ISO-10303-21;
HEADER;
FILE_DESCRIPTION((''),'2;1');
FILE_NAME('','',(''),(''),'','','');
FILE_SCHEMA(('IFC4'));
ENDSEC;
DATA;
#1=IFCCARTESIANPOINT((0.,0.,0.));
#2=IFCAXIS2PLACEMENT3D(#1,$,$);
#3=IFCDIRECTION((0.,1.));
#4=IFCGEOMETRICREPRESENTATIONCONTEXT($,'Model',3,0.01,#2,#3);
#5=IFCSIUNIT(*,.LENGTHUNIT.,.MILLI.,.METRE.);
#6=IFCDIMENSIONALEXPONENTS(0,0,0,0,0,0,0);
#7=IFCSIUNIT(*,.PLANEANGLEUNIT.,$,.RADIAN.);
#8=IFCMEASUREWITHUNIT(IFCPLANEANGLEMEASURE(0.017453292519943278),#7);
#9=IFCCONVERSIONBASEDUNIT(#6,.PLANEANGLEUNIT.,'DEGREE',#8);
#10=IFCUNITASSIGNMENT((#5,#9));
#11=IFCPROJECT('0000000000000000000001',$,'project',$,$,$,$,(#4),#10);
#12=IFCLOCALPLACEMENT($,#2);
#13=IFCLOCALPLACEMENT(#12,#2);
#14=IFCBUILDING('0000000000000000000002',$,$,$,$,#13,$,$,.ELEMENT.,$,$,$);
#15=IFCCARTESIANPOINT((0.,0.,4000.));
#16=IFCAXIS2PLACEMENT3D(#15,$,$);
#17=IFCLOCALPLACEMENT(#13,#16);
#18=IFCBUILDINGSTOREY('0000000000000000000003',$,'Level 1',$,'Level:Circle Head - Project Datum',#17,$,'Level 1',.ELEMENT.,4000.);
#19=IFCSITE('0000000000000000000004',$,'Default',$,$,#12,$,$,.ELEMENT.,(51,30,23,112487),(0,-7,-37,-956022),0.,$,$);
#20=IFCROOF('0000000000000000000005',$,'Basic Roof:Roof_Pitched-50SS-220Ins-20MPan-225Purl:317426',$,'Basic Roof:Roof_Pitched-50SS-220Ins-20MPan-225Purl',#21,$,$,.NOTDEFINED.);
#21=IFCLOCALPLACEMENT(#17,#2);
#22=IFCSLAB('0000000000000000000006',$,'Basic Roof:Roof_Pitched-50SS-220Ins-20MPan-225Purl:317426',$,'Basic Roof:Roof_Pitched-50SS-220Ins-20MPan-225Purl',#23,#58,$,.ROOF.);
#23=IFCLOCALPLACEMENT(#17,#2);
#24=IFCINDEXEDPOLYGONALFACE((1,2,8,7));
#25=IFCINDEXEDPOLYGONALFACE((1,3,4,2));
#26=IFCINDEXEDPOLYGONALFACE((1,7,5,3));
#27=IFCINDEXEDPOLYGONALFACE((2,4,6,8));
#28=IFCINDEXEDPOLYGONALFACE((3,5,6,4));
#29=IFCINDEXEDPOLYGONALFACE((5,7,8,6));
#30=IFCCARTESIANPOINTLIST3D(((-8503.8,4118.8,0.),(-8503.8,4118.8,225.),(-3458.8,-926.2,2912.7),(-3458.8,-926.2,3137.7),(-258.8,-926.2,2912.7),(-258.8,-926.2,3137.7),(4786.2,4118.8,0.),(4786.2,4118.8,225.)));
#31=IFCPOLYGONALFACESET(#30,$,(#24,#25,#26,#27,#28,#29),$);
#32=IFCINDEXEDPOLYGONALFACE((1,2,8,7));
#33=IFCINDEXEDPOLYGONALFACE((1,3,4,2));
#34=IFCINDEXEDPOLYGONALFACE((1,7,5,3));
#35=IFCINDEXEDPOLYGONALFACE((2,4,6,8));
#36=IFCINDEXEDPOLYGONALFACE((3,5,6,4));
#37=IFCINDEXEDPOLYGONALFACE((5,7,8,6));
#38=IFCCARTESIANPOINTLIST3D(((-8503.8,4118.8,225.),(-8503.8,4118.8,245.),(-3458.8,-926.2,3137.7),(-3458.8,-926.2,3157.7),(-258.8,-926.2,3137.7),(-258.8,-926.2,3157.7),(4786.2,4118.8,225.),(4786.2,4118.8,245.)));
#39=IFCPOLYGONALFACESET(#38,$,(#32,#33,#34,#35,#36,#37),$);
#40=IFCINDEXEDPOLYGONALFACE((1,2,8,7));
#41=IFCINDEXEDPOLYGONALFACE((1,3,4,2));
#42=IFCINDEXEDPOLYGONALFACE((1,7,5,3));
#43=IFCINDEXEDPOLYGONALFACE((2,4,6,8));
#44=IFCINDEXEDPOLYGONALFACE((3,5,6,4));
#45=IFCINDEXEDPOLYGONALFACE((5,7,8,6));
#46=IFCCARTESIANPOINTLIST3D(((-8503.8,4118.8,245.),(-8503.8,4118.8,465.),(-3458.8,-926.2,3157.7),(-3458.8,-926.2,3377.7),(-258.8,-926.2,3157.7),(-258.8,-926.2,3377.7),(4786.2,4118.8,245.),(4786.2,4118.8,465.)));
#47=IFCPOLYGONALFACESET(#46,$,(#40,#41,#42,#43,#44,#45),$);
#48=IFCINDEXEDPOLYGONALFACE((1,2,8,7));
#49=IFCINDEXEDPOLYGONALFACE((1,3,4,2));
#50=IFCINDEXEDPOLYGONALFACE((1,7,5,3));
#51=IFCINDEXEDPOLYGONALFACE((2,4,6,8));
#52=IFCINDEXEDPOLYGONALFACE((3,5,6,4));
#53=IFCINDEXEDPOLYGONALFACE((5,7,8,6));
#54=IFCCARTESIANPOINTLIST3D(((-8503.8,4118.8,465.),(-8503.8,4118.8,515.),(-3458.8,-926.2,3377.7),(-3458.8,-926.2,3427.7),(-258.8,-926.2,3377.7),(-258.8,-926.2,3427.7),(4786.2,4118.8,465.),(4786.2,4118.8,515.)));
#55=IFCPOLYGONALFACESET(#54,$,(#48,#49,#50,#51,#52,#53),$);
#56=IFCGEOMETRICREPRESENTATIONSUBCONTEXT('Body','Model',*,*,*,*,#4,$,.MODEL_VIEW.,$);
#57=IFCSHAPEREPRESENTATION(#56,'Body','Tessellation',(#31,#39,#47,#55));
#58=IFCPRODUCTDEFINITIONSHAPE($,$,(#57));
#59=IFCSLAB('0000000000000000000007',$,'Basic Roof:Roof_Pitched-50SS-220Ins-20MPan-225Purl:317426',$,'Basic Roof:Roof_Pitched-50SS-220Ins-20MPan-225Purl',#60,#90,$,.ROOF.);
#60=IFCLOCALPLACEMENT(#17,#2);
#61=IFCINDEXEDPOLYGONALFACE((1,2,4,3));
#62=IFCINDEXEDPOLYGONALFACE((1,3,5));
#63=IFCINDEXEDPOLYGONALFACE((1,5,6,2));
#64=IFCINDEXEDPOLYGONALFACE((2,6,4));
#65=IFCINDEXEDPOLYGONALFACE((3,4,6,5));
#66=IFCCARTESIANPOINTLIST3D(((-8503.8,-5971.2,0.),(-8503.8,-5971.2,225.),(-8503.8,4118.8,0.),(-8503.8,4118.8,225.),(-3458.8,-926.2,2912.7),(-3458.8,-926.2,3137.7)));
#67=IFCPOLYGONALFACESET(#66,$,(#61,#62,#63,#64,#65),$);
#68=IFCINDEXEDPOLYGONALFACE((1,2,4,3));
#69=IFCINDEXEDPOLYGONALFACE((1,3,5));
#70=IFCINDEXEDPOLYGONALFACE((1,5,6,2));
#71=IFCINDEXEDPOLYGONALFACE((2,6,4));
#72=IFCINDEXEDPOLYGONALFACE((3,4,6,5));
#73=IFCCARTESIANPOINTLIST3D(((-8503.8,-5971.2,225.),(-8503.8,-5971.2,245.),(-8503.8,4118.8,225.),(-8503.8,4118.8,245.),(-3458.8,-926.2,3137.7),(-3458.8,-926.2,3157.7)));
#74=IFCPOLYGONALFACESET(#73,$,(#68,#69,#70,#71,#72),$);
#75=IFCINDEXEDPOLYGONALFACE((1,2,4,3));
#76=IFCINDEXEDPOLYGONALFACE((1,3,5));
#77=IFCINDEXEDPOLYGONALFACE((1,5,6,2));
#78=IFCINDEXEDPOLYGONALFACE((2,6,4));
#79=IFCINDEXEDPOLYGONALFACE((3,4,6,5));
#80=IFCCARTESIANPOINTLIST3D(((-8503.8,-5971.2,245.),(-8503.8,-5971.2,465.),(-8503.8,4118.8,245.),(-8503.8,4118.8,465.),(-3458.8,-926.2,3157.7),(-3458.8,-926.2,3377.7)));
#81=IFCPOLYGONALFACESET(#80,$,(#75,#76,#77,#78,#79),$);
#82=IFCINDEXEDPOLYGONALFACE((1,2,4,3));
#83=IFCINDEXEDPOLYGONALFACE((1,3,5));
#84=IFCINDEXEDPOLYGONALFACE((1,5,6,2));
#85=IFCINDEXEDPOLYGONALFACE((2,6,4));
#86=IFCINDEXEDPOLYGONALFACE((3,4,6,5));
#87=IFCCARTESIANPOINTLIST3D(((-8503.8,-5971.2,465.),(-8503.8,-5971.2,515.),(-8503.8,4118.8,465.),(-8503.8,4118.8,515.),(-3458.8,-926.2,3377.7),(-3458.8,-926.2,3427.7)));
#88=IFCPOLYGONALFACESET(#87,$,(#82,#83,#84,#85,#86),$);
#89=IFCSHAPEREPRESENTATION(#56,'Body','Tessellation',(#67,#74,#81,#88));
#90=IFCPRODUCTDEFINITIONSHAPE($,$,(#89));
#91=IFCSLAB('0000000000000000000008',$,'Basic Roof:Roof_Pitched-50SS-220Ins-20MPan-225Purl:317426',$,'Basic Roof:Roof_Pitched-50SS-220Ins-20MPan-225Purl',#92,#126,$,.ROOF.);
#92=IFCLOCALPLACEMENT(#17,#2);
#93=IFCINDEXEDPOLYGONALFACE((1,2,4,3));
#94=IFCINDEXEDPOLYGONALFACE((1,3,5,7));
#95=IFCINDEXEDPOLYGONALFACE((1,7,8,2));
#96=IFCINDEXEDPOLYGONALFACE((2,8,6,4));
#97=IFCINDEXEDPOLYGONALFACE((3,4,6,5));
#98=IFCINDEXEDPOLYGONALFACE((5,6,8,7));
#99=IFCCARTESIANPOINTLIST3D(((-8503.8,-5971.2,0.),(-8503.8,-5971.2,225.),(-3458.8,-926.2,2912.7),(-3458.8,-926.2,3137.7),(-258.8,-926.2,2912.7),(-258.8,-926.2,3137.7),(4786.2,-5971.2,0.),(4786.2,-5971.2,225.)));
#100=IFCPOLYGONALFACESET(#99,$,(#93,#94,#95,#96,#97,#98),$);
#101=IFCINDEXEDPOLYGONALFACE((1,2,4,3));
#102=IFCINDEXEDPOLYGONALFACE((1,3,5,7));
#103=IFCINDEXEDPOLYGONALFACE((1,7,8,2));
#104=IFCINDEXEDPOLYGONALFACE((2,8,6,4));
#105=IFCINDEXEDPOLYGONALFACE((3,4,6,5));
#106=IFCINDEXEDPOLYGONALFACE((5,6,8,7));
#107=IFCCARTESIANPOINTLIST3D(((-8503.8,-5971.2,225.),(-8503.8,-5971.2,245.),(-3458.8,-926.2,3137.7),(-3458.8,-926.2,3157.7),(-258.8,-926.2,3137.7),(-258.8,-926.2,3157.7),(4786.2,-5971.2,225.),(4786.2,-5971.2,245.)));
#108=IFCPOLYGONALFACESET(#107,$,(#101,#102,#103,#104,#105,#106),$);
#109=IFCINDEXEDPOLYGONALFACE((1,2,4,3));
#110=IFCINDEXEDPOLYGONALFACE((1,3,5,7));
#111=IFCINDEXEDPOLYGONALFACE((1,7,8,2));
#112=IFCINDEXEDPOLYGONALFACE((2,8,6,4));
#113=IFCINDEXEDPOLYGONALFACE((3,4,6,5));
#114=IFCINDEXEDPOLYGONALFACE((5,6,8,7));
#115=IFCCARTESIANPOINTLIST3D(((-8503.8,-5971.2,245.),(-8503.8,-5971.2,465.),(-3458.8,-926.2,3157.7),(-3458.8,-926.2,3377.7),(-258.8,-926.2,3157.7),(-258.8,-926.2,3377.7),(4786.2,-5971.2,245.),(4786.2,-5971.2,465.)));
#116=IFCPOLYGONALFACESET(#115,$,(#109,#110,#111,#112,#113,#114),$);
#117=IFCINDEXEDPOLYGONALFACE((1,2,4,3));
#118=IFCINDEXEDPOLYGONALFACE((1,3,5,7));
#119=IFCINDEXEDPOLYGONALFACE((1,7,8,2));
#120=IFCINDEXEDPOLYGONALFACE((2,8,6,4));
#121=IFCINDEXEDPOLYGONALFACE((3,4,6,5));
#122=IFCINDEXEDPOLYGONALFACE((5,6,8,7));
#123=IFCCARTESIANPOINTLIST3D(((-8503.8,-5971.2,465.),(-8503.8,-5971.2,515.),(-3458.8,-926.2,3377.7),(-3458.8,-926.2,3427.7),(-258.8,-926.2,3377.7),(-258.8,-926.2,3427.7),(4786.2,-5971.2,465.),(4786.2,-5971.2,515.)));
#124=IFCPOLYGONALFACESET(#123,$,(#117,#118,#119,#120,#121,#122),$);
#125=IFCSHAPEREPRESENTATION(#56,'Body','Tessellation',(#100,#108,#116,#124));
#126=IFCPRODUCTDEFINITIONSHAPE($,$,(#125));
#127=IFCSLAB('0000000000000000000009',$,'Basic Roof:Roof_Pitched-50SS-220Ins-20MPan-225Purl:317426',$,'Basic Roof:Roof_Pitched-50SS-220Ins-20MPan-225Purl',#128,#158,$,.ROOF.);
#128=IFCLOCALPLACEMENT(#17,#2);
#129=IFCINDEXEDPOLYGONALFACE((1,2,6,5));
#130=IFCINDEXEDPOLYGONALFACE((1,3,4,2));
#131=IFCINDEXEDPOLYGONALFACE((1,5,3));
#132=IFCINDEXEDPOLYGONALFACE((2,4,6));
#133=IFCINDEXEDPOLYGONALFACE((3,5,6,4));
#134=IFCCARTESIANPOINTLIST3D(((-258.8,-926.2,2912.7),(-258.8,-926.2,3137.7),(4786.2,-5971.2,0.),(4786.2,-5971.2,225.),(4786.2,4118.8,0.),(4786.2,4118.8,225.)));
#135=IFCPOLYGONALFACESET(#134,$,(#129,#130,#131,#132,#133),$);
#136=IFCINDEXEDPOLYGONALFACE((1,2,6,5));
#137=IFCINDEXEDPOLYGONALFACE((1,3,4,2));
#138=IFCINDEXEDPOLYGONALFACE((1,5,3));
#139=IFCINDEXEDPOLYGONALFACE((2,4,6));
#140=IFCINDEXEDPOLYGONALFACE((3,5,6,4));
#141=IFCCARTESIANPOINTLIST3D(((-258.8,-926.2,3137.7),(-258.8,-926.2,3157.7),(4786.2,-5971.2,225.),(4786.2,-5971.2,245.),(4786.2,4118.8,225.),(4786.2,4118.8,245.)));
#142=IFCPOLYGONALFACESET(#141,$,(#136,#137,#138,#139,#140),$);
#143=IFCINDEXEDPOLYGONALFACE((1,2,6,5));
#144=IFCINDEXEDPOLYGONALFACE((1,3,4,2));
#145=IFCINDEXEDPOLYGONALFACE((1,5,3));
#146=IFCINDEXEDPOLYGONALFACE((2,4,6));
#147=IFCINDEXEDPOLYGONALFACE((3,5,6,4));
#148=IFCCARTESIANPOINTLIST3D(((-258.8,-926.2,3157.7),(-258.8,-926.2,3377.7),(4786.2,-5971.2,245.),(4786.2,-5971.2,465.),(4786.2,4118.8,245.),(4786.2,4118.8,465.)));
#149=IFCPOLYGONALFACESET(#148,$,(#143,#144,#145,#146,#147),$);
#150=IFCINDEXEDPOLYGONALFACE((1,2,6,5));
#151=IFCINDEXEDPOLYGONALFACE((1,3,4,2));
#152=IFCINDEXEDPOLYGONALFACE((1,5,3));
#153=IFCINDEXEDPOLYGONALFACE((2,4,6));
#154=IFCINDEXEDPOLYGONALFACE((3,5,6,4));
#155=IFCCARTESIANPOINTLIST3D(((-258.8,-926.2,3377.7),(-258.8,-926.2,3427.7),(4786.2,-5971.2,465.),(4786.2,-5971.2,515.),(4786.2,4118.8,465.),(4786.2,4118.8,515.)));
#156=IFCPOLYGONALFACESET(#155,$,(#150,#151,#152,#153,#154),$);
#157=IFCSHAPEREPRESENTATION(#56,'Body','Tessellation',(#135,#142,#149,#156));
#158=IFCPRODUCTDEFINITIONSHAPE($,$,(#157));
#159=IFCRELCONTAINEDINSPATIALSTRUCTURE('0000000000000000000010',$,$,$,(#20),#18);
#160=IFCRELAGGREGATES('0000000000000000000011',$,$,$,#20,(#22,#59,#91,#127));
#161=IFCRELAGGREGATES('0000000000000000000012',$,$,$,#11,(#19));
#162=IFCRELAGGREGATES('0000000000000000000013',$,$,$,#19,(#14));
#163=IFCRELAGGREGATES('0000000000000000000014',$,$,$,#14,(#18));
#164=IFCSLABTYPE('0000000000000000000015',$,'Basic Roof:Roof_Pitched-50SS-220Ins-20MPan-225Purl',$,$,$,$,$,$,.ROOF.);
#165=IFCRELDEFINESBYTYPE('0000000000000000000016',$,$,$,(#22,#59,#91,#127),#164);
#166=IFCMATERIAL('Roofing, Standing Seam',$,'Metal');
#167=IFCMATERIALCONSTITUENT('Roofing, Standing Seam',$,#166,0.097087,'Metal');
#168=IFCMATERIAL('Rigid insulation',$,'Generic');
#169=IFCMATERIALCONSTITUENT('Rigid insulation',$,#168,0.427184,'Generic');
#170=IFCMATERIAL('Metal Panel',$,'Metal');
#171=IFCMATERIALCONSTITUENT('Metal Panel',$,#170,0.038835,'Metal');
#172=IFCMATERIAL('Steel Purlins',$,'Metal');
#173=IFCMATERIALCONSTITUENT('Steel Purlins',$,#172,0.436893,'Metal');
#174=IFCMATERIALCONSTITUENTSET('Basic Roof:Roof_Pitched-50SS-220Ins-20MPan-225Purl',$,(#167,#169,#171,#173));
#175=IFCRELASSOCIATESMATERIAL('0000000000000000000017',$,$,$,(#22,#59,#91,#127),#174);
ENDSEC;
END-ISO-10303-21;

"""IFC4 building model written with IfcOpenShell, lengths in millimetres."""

from ifc_helpers import new_model, entity, si_unit, converted_unit, direction, frame, origin, place, context, subcontext, project, spatial, indexed_curve, outline, extrude, material, constituent, constituent_set, type_object, element, aggregate, save


model = new_model("IFC4")

# Units and contexts
model_context = context("Model", 3, precision=0.01, world=origin(), true_north=direction((0.0, 1.0)))
body_context = subcontext(model_context, "Body", "Model", "MODEL_VIEW")
ifc_project = project(units=[si_unit("LENGTHUNIT", "METRE", prefix="MILLI"), converted_unit("PLANEANGLEUNIT", "DEGREE", entity("IfcPlaneAngleMeasure", 0.017453292519943278), si_unit("PLANEANGLEUNIT", "RADIAN"), dimensions=[0, 0, 0, 0, 0, 0, 0])], contexts=[model_context])

# Site, building, storey
site_placement = place(None, origin())
site = spatial("IfcSite", under=ifc_project, at=site_placement, Name="Default", CompositionType="ELEMENT", RefLatitude=(51, 30, 23, 112487), RefLongitude=(0, -7, -37, -956022), RefElevation=0.0)
building_placement = place(site_placement, origin())
building = spatial("IfcBuilding", under=site, at=building_placement, CompositionType="ELEMENT")
storey_placement = place(building_placement, frame((0.0, 0.0, 4000.0)))
storey = spatial("IfcBuildingStorey", under=building, at=storey_placement, Name="Level 1", ObjectType="Level:Circle Head - Project Datum", LongName="Level 1", CompositionType="ELEMENT", Elevation=4000.0)

# Roof, slabs
roof_placement = place(storey_placement, frame((-8503.8, -5971.2, 0.0)))
roof = element("IfcRoof", 1, at=roof_placement, inside=storey, Name="Basic Roof:Roof_Pitched-50SS-220Ins-20MPan-225Purl:317426", ObjectType="Basic Roof:Roof_Pitched-50SS-220Ins-20MPan-225Purl", PredefinedType="NOTDEFINED")
ifc_material_1 = material(Name="Roofing, Standing Seam", Category="Metal")
ifc_constituent_1 = constituent(ifc_material_1, Name="Roofing, Standing Seam", Category="Metal", fraction=0.097087)
ifc_material_2 = material(Name="Rigid insulation", Category="Generic")
ifc_constituent_2 = constituent(ifc_material_2, Name="Rigid insulation", Category="Generic", fraction=0.427184)
ifc_material_3 = material(Name="Metal Panel", Category="Metal")
ifc_constituent_3 = constituent(ifc_material_3, Name="Metal Panel", Category="Metal", fraction=0.038835)
ifc_material_4 = material(Name="Steel Purlins", Category="Metal")
ifc_constituent_4 = constituent(ifc_material_4, Name="Steel Purlins", Category="Metal", fraction=0.436893)
ifc_constituent_set = constituent_set(constituents=[ifc_constituent_1, ifc_constituent_2, ifc_constituent_3, ifc_constituent_4], Name="Basic Roof:Roof_Pitched-50SS-220Ins-20MPan-225Purl")
slab_type = type_object("IfcSlabType", Name="Basic Roof:Roof_Pitched-50SS-220Ins-20MPan-225Purl", PredefinedType="ROOF")
slab_1_placement = place(roof_placement, origin())
slab_1 = element("IfcSlab", 2, at=slab_1_placement, type_object=slab_type, material=ifc_constituent_set, Name="Basic Roof:Roof_Pitched-50SS-220Ins-20MPan-225Purl:317426", ObjectType="Basic Roof:Roof_Pitched-50SS-220Ins-20MPan-225Purl", PredefinedType="ROOF", context=body_context, shape_type="SweptSolid", body=[
    extrude(outline(indexed_curve([(6645.0, 2912.7), (-6645.0, 2912.7), (-1600.0, -2912.7), (1600.0, -2912.7), (6645.0, 2912.7)], self_intersect=False)), frame((6645.0, 7567.5, 1456.4), z_axis=(0.0, 0.5, 0.866025), x_axis=(1.0, 0.0, 0.0)), (0.0, -0.5, 0.866025), 225.0),
    extrude(outline(indexed_curve([(6645.0, 2912.7), (-6645.0, 2912.7), (-1600.0, -2912.7), (1600.0, -2912.7), (6645.0, 2912.7)], self_intersect=False)), frame((6645.0, 7567.5, 1681.4), z_axis=(0.0, 0.5, 0.866025), x_axis=(1.0, 0.0, 0.0)), (0.0, -0.5, 0.866025), 20.0),
    extrude(outline(indexed_curve([(6645.0, 2912.7), (-6645.0, 2912.7), (-1600.0, -2912.7), (1600.0, -2912.7), (6645.0, 2912.7)], self_intersect=False)), frame((6645.0, 7567.5, 1701.4), z_axis=(0.0, 0.5, 0.866025), x_axis=(1.0, 0.0, 0.0)), (0.0, -0.5, 0.866025), 220.0),
    extrude(outline(indexed_curve([(6645.0, 2912.7), (-6645.0, 2912.7), (-1600.0, -2912.7), (1600.0, -2912.7), (6645.0, 2912.7)], self_intersect=False)), frame((6645.0, 7567.5, 1921.4), z_axis=(0.0, 0.5, 0.866025), x_axis=(1.0, 0.0, 0.0)), (0.0, -0.5, 0.866025), 50.0),
])
slab_2_placement = place(roof_placement, origin())
slab_2 = element("IfcSlab", 3, at=slab_2_placement, type_object=slab_type, material=ifc_constituent_set, Name="Basic Roof:Roof_Pitched-50SS-220Ins-20MPan-225Purl:317426", ObjectType="Basic Roof:Roof_Pitched-50SS-220Ins-20MPan-225Purl", PredefinedType="ROOF", context=body_context, shape_type="SweptSolid", body=[
    extrude(outline(indexed_curve([(-2912.7, 5045.0), (-2912.7, -5045.0), (2912.7, 0.0), (-2912.7, 5045.0)], self_intersect=False)), frame((2522.5, 5045.0, 1456.4), z_axis=(-0.5, 0.0, 0.866025), x_axis=(0.866025, 0.0, 0.5)), (0.5, 0.0, 0.866025), 225.0),
    extrude(outline(indexed_curve([(-2912.7, 5045.0), (-2912.7, -5045.0), (2912.7, 0.0), (-2912.7, 5045.0)], self_intersect=False)), frame((2522.5, 5045.0, 1681.4), z_axis=(-0.5, 0.0, 0.866025), x_axis=(0.866025, 0.0, 0.5)), (0.5, 0.0, 0.866025), 20.0),
    extrude(outline(indexed_curve([(-2912.7, 5045.0), (-2912.7, -5045.0), (2912.7, 0.0), (-2912.7, 5045.0)], self_intersect=False)), frame((2522.5, 5045.0, 1701.4), z_axis=(-0.5, 0.0, 0.866025), x_axis=(0.866025, 0.0, 0.5)), (0.5, 0.0, 0.866025), 220.0),
    extrude(outline(indexed_curve([(-2912.7, 5045.0), (-2912.7, -5045.0), (2912.7, 0.0), (-2912.7, 5045.0)], self_intersect=False)), frame((2522.5, 5045.0, 1921.4), z_axis=(-0.5, 0.0, 0.866025), x_axis=(0.866025, 0.0, 0.5)), (0.5, 0.0, 0.866025), 50.0),
])
slab_3_placement = place(roof_placement, origin())
slab_3 = element("IfcSlab", 4, at=slab_3_placement, type_object=slab_type, material=ifc_constituent_set, Name="Basic Roof:Roof_Pitched-50SS-220Ins-20MPan-225Purl:317426", ObjectType="Basic Roof:Roof_Pitched-50SS-220Ins-20MPan-225Purl", PredefinedType="ROOF", context=body_context, shape_type="SweptSolid", body=[
    extrude(outline(indexed_curve([(-6645.0, -2912.7), (6645.0, -2912.7), (1600.0, 2912.7), (-1600.0, 2912.7), (-6645.0, -2912.7)], self_intersect=False)), frame((6645.0, 2522.5, 1456.4), z_axis=(0.0, -0.5, 0.866025), x_axis=(1.0, 0.0, 0.0)), (0.0, 0.5, 0.866025), 225.0),
    extrude(outline(indexed_curve([(-6645.0, -2912.7), (6645.0, -2912.7), (1600.0, 2912.7), (-1600.0, 2912.7), (-6645.0, -2912.7)], self_intersect=False)), frame((6645.0, 2522.5, 1681.4), z_axis=(0.0, -0.5, 0.866025), x_axis=(1.0, 0.0, 0.0)), (0.0, 0.5, 0.866025), 20.0),
    extrude(outline(indexed_curve([(-6645.0, -2912.7), (6645.0, -2912.7), (1600.0, 2912.7), (-1600.0, 2912.7), (-6645.0, -2912.7)], self_intersect=False)), frame((6645.0, 2522.5, 1701.4), z_axis=(0.0, -0.5, 0.866025), x_axis=(1.0, 0.0, 0.0)), (0.0, 0.5, 0.866025), 220.0),
    extrude(outline(indexed_curve([(-6645.0, -2912.7), (6645.0, -2912.7), (1600.0, 2912.7), (-1600.0, 2912.7), (-6645.0, -2912.7)], self_intersect=False)), frame((6645.0, 2522.5, 1921.4), z_axis=(0.0, -0.5, 0.866025), x_axis=(1.0, 0.0, 0.0)), (0.0, 0.5, 0.866025), 50.0),
])
slab_4_placement = place(roof_placement, origin())
slab_4 = element("IfcSlab", 5, at=slab_4_placement, type_object=slab_type, material=ifc_constituent_set, Name="Basic Roof:Roof_Pitched-50SS-220Ins-20MPan-225Purl:317426", ObjectType="Basic Roof:Roof_Pitched-50SS-220Ins-20MPan-225Purl", PredefinedType="ROOF", context=body_context, shape_type="SweptSolid", body=[
    extrude(outline(indexed_curve([(-2912.7, 0.0), (2912.7, -5045.0), (2912.7, 5045.0), (-2912.7, 0.0)], self_intersect=False)), frame((10767.5, 5045.0, 1456.4), z_axis=(0.5, 0.0, 0.866025), x_axis=(0.866025, 0.0, -0.5)), (-0.5, 0.0, 0.866025), 225.0),
    extrude(outline(indexed_curve([(-2912.7, 0.0), (2912.7, -5045.0), (2912.7, 5045.0), (-2912.7, 0.0)], self_intersect=False)), frame((10767.5, 5045.0, 1681.4), z_axis=(0.5, 0.0, 0.866025), x_axis=(0.866025, 0.0, -0.5)), (-0.5, 0.0, 0.866025), 20.0),
    extrude(outline(indexed_curve([(-2912.7, 0.0), (2912.7, -5045.0), (2912.7, 5045.0), (-2912.7, 0.0)], self_intersect=False)), frame((10767.5, 5045.0, 1701.4), z_axis=(0.5, 0.0, 0.866025), x_axis=(0.866025, 0.0, -0.5)), (-0.5, 0.0, 0.866025), 220.0),
    extrude(outline(indexed_curve([(-2912.7, 0.0), (2912.7, -5045.0), (2912.7, 5045.0), (-2912.7, 0.0)], self_intersect=False)), frame((10767.5, 5045.0, 1921.4), z_axis=(0.5, 0.0, 0.866025), x_axis=(0.866025, 0.0, -0.5)), (-0.5, 0.0, 0.866025), 50.0),
])
aggregate(roof, [slab_1, slab_2, slab_3, slab_4])

save(model, "model.ifc")
